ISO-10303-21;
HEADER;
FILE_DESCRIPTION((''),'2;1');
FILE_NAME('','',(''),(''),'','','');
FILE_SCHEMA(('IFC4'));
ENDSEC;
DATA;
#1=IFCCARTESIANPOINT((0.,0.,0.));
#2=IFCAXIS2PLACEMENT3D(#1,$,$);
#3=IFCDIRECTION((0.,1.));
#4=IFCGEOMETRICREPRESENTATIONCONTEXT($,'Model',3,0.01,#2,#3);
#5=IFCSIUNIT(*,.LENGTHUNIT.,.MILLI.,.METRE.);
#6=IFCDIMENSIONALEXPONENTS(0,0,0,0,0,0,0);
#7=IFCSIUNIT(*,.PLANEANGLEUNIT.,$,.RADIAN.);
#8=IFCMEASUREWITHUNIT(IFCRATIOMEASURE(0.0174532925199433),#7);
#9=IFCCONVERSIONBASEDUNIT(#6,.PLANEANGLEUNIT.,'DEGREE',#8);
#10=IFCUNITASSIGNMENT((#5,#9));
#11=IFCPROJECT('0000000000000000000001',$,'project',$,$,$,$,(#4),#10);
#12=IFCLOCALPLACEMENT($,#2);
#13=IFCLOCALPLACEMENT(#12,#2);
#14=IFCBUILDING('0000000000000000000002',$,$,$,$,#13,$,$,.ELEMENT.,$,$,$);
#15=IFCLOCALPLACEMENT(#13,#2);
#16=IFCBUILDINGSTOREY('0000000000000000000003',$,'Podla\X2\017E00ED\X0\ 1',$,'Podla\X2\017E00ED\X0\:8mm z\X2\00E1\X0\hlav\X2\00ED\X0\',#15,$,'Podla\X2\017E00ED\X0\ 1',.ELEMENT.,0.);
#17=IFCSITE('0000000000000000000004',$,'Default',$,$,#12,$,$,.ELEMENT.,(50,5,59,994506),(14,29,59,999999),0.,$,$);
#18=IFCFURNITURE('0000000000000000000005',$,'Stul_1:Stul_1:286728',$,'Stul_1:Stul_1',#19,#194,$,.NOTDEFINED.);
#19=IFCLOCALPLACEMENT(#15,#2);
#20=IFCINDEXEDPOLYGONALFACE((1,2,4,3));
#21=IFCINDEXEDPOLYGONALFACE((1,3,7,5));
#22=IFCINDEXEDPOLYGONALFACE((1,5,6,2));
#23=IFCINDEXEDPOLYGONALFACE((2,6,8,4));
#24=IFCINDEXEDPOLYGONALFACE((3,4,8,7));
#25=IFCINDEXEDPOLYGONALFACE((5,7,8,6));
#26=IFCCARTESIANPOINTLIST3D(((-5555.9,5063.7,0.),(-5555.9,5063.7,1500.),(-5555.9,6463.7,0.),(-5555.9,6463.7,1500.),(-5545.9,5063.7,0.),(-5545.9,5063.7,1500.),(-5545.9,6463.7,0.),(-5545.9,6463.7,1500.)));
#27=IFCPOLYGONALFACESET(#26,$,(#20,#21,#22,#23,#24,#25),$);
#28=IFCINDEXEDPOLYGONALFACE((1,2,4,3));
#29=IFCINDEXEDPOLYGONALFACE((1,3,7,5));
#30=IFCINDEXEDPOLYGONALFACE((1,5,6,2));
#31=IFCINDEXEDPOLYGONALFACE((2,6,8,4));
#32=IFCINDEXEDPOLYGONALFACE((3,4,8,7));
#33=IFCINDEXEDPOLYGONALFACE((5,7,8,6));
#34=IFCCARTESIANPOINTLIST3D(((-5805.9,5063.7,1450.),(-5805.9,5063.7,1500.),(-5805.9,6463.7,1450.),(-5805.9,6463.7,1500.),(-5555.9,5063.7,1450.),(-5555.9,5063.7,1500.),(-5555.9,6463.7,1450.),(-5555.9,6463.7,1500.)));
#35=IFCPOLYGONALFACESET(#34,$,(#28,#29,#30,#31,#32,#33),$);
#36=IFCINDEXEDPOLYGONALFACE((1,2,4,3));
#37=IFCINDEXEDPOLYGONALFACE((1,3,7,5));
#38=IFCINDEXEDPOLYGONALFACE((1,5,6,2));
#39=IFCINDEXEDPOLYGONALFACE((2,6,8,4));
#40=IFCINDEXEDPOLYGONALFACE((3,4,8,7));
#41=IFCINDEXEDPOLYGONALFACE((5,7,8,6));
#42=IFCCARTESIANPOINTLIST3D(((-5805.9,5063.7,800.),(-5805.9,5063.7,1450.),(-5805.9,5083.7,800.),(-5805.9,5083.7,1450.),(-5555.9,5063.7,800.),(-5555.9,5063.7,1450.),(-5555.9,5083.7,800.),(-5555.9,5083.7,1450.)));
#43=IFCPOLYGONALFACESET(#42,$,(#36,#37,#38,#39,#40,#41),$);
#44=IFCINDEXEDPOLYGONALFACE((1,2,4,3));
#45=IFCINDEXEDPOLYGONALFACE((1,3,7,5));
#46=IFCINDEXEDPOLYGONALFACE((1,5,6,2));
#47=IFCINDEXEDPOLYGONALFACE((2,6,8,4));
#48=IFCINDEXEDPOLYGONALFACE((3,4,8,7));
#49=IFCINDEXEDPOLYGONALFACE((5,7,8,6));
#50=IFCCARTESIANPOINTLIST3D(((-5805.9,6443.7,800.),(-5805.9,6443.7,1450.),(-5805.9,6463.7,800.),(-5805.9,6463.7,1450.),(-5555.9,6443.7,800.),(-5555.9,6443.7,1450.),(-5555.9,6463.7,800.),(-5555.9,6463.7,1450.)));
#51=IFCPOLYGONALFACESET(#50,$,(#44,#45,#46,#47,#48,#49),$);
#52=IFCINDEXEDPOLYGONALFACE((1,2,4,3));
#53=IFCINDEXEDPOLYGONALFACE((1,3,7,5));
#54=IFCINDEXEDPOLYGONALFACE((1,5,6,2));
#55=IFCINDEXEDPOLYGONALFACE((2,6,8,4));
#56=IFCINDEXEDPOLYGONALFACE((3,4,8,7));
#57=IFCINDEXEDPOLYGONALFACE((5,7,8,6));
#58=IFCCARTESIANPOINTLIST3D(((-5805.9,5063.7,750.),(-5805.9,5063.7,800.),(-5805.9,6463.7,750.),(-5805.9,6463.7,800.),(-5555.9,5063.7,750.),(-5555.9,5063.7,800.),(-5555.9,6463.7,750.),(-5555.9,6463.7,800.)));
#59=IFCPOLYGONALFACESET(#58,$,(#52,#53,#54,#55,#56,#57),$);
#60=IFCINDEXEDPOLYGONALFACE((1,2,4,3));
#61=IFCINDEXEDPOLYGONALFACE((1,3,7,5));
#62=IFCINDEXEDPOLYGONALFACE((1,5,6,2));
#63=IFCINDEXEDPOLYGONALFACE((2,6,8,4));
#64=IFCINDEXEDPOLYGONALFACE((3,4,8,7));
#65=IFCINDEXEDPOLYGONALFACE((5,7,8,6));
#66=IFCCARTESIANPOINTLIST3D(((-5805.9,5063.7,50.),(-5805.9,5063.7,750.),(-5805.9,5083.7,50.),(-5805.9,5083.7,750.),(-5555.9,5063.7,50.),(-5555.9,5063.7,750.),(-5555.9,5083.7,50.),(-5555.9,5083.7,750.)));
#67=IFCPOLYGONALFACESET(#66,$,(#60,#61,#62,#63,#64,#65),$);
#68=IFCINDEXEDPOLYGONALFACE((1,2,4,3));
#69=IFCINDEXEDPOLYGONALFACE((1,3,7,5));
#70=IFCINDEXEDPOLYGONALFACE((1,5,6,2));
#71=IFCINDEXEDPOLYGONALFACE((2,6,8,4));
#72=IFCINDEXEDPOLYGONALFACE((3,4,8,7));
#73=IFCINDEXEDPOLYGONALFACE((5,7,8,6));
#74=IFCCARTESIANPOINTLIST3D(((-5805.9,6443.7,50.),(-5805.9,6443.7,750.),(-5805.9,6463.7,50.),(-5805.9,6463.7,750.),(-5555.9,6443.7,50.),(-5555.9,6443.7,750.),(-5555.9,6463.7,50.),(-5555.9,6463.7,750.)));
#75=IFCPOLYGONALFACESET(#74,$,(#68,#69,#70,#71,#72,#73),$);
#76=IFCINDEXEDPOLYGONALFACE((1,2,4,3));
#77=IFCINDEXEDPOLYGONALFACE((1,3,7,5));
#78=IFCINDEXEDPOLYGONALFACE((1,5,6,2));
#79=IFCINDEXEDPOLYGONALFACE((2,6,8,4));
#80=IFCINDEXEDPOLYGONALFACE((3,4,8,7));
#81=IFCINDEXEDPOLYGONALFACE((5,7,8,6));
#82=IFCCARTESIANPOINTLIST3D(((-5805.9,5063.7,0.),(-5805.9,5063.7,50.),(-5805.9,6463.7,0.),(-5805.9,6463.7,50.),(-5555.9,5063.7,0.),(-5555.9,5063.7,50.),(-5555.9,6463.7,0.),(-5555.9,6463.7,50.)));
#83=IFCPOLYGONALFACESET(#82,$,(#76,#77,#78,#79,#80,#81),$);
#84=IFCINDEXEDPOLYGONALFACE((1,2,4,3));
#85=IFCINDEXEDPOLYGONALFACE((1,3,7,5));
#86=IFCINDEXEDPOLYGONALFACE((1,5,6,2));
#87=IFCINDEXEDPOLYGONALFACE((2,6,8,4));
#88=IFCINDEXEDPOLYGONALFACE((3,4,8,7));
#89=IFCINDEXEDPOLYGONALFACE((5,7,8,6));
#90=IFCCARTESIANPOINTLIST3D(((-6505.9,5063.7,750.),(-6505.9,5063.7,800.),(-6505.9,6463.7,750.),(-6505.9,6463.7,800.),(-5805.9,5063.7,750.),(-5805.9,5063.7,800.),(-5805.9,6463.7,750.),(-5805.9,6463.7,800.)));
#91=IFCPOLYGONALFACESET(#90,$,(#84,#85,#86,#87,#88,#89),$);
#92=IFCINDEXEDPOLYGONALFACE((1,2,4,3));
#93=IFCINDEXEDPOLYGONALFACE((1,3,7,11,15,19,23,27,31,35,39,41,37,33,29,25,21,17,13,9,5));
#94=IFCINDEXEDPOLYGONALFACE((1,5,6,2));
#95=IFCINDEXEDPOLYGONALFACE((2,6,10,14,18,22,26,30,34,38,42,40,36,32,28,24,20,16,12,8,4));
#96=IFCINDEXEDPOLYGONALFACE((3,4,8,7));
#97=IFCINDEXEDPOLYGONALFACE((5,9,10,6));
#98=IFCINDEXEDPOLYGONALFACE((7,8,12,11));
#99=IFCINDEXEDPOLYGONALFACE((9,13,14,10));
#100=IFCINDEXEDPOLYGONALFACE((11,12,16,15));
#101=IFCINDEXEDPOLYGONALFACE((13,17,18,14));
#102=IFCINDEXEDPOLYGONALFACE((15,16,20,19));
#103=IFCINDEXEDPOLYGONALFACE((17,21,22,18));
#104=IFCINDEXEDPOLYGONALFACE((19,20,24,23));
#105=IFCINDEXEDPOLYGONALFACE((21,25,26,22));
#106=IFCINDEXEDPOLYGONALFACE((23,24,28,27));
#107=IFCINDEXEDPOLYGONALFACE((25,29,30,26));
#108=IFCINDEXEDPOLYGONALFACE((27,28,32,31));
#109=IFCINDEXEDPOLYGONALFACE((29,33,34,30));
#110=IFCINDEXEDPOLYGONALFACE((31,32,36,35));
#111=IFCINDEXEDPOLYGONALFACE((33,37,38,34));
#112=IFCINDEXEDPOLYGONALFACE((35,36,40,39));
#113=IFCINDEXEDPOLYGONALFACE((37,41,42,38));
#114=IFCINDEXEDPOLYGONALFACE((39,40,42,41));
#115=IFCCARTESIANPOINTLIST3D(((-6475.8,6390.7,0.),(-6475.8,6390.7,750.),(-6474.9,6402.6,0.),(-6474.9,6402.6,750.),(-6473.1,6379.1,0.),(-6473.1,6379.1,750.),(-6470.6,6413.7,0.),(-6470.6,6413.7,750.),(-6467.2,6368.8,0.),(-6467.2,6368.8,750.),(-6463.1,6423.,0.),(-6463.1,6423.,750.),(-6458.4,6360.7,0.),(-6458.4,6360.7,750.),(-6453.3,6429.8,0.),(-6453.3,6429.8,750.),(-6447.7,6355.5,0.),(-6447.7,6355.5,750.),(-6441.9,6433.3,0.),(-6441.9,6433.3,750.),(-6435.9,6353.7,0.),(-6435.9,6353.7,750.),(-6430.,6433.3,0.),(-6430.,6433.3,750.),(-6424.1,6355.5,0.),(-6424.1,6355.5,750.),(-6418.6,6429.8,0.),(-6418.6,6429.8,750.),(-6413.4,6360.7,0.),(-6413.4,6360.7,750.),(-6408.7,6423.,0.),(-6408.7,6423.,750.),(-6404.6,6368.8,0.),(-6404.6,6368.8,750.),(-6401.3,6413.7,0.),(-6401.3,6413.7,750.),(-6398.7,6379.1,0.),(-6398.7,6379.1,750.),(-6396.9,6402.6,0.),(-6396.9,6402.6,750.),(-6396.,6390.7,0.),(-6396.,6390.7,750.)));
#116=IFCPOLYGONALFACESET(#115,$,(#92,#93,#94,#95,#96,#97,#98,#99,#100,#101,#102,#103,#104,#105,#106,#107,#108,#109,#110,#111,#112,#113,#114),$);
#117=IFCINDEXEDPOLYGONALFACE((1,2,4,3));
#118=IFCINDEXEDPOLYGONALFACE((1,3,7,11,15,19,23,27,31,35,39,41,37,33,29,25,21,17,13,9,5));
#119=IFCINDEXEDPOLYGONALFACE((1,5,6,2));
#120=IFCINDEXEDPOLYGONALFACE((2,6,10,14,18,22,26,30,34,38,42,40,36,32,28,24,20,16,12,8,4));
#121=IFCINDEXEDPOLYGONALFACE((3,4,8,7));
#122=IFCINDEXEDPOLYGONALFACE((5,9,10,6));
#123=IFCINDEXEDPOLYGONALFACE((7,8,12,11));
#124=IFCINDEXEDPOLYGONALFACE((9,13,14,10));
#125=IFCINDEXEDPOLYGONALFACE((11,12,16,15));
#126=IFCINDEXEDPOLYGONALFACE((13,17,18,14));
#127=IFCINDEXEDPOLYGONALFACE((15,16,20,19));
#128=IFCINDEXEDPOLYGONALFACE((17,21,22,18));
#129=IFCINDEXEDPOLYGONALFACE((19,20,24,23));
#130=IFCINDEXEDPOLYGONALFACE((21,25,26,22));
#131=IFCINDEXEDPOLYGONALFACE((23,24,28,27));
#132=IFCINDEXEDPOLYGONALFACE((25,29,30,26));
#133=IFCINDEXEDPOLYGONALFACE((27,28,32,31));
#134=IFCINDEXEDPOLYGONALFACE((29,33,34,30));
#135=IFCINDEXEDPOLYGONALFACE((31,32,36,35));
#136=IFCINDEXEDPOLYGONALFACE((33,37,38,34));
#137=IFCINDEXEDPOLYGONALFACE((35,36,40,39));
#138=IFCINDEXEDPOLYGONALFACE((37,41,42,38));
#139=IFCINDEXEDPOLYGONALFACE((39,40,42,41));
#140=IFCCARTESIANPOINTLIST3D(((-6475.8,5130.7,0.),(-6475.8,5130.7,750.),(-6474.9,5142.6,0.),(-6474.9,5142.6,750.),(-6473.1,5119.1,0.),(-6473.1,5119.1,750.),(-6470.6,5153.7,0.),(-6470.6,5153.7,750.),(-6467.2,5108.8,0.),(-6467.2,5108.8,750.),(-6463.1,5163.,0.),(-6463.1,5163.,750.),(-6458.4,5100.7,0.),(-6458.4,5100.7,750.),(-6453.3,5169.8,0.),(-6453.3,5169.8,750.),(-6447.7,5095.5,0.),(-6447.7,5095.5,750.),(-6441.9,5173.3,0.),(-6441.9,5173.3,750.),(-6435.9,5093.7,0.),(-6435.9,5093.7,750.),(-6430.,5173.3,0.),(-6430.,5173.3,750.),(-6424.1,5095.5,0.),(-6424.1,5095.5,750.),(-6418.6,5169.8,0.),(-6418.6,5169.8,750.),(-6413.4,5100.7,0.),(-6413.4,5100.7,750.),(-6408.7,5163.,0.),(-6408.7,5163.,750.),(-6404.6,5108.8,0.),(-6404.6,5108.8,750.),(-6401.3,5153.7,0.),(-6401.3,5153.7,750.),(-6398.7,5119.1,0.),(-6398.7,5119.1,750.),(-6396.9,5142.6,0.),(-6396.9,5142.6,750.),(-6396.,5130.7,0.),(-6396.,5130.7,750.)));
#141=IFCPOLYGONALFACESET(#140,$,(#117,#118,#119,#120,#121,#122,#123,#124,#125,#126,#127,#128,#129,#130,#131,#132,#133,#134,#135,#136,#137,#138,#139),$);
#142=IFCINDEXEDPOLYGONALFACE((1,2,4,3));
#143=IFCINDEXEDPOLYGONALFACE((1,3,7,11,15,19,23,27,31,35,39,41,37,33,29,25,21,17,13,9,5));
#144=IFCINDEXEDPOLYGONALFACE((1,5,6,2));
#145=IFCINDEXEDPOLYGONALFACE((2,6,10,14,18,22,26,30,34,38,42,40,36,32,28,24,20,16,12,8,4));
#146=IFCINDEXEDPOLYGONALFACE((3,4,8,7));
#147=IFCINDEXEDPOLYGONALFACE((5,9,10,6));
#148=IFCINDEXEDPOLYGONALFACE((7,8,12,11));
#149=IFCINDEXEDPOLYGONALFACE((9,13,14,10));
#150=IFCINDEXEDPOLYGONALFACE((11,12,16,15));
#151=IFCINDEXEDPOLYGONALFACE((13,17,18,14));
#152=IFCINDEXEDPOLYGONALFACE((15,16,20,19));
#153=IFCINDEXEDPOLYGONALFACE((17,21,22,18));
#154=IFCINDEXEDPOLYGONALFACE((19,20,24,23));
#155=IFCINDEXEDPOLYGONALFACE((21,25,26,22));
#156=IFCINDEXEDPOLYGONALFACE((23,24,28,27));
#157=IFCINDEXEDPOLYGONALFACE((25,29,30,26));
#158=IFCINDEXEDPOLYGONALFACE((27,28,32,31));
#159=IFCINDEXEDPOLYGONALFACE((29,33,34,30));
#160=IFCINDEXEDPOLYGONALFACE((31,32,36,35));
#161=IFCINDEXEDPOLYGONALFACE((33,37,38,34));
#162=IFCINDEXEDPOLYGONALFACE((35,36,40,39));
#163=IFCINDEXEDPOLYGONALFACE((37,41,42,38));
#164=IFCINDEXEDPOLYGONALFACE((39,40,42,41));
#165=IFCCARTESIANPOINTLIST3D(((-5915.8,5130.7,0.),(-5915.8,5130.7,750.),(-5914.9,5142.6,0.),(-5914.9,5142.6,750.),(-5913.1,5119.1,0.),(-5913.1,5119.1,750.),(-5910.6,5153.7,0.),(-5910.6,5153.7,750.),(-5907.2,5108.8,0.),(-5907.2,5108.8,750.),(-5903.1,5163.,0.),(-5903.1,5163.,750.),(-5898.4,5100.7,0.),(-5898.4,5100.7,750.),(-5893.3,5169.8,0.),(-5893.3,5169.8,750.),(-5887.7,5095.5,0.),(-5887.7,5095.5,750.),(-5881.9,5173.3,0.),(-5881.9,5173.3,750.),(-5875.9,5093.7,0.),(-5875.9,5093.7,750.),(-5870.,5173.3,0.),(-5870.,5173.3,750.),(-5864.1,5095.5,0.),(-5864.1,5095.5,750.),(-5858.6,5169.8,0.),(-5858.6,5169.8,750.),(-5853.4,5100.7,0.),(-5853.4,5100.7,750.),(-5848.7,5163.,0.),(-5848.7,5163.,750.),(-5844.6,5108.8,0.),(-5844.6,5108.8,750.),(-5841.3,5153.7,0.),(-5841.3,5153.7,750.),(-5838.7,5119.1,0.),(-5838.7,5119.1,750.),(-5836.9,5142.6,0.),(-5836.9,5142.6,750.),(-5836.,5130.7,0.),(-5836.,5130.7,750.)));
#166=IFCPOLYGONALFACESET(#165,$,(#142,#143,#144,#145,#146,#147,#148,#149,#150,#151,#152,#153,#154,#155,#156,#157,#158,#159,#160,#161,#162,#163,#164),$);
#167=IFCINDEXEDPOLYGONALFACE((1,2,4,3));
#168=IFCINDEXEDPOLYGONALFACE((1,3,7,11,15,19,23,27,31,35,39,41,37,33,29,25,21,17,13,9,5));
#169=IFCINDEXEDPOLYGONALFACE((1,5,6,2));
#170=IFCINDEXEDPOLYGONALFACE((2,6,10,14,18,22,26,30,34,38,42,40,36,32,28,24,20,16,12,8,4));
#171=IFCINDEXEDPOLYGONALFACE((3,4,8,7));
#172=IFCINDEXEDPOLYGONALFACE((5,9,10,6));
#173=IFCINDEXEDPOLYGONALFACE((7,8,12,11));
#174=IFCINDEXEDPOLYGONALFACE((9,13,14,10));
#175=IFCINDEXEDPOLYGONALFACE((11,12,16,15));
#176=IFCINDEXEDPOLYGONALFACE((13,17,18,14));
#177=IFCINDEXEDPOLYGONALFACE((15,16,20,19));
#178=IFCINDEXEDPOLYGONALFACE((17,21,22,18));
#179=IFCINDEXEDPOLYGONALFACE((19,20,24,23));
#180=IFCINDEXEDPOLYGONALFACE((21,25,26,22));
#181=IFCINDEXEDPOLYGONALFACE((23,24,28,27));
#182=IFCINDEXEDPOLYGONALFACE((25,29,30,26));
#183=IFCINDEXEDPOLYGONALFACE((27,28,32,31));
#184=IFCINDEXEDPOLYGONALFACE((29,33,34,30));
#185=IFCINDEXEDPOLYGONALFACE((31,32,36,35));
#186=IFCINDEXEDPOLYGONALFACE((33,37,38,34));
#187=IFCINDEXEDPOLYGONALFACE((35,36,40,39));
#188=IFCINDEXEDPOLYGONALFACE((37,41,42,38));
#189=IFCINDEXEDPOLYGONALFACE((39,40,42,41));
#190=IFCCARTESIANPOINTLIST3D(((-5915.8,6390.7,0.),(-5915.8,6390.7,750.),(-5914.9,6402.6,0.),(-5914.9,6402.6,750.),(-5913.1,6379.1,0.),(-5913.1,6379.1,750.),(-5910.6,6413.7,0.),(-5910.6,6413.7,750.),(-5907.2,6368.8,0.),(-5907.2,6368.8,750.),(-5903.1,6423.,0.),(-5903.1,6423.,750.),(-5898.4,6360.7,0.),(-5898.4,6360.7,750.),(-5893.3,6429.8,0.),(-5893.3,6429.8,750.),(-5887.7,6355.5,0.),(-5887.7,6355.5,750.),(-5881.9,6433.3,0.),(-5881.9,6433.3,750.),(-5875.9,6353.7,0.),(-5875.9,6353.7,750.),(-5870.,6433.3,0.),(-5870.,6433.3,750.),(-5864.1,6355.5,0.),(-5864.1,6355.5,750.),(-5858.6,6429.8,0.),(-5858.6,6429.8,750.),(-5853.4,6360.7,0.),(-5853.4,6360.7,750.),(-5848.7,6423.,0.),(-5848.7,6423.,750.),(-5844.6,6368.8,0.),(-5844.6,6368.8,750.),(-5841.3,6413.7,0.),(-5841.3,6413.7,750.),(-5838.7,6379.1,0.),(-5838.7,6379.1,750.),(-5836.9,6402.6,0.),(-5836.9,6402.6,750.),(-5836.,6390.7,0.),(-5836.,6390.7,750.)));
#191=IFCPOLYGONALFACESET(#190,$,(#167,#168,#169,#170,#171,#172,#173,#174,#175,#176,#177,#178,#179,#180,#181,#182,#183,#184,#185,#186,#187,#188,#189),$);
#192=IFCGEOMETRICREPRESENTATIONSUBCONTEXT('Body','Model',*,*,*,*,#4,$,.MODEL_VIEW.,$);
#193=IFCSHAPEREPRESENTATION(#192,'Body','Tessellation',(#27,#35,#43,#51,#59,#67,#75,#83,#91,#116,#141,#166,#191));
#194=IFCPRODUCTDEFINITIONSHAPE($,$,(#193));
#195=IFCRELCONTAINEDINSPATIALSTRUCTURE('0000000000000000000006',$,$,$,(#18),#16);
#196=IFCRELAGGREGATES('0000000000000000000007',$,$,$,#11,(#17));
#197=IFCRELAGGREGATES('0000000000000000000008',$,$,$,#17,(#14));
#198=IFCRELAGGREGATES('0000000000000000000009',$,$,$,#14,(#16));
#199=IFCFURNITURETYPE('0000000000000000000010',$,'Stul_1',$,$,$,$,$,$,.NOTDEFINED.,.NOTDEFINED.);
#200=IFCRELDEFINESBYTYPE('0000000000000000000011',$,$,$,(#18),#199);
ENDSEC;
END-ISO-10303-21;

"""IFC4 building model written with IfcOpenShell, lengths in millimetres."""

from ifc_helpers import new_model, entity, si_unit, converted_unit, direction, frame, frame_2d, origin, origin_2d_with_axis, place, context, subcontext, project, spatial, rectangle, circle, extrude, source, transform, mapped, type_object, type_shapes, element, save


model = new_model("IFC4")

# Units and contexts
model_context = context("Model", 3, precision=0.01, world=origin(), true_north=direction((0.0, 1.0)))
body_context = subcontext(model_context, "Body", "Model", "MODEL_VIEW")
ifc_project = project(units=[si_unit("LENGTHUNIT", "METRE", prefix="MILLI"), converted_unit("PLANEANGLEUNIT", "DEGREE", entity("IfcRatioMeasure", 0.0174532925199433), si_unit("PLANEANGLEUNIT", "RADIAN"), dimensions=[0, 0, 0, 0, 0, 0, 0])], contexts=[model_context])

# Site, building, storey
site_placement = place(None, origin())
site = spatial("IfcSite", under=ifc_project, at=site_placement, Name="Default", CompositionType="ELEMENT", RefLatitude=(50, 5, 59, 994506), RefLongitude=(14, 29, 59, 999999), RefElevation=0.0)
building_placement = place(site_placement, origin())
building = spatial("IfcBuilding", under=site, at=building_placement, CompositionType="ELEMENT")
storey_placement = place(building_placement, origin())
storey = spatial("IfcBuildingStorey", under=building, at=storey_placement, Name="Podlaží 1", ObjectType="Podlaží:8mm záhlaví", LongName="Podlaží 1", CompositionType="ELEMENT", Elevation=0.0)

# Furniture
furniture_type = type_object("IfcFurnitureType", Name="Stul_1", AssemblyPlace="NOTDEFINED", PredefinedType="NOTDEFINED")
shared_shape_1 = source(origin(), body_context, "Body", "SweptSolid", [
    extrude(rectangle(XDim=1400.0, YDim=10.0, at=origin_2d_with_axis()), frame((0.0, 605.0, 0.0), z_axis=(0.0, 0.0, 1.0), x_axis=(-1.0, 0.0, 0.0)), (0.0, 0.0, 1.0), 1500.0),
    extrude(rectangle(XDim=1400.0, YDim=250.0, at=frame_2d((0.0, 0.0), x_axis=(1.0, 0.0))), frame((0.0, 475.0, 1450.0), z_axis=(0.0, 0.0, 1.0), x_axis=(-1.0, 0.0, 0.0)), (0.0, 0.0, 1.0), 50.0),
    extrude(rectangle(XDim=20.0, YDim=250.0, at=origin_2d_with_axis()), frame((690.0, 475.0, 800.0), z_axis=(0.0, 0.0, 1.0), x_axis=(-1.0, 0.0, 0.0)), (0.0, 0.0, 1.0), 650.0),
    extrude(rectangle(XDim=20.0, YDim=250.0, at=frame_2d((0.0, 0.0), x_axis=(1.0, 0.0))), frame((-690.0, 475.0, 800.0), z_axis=(0.0, 0.0, 1.0), x_axis=(-1.0, 0.0, 0.0)), (0.0, 0.0, 1.0), 650.0),
    extrude(rectangle(XDim=1400.0, YDim=250.0, at=origin_2d_with_axis()), frame((0.0, 475.0, 750.0), z_axis=(0.0, 0.0, 1.0), x_axis=(-1.0, 0.0, 0.0)), (0.0, 0.0, 1.0), 50.0),
    extrude(rectangle(XDim=20.0, YDim=250.0, at=origin_2d_with_axis()), frame((690.0, 475.0, 50.0), z_axis=(0.0, 0.0, 1.0), x_axis=(-1.0, 0.0, 0.0)), (0.0, 0.0, 1.0), 700.0),
    extrude(rectangle(XDim=20.0, YDim=250.0, at=frame_2d((0.0, 0.0), x_axis=(1.0, 0.0))), frame((-690.0, 475.0, 50.0), z_axis=(0.0, 0.0, 1.0), x_axis=(-1.0, 0.0, 0.0)), (0.0, 0.0, 1.0), 700.0),
    extrude(rectangle(XDim=1400.0, YDim=250.0, at=origin_2d_with_axis()), frame((0.0, 475.0, 0.0), z_axis=(0.0, 0.0, 1.0), x_axis=(-1.0, 0.0, 0.0)), (0.0, 0.0, 1.0), 50.0),
    extrude(rectangle(XDim=1400.0, YDim=700.0, at=origin_2d_with_axis()), frame((0.0, 0.0, 750.0), z_axis=(0.0, 0.0, 1.0), x_axis=(-1.0, 0.0, 0.0)), (0.0, 0.0, 1.0), 50.0),
    extrude(circle(Radius=40.0, at=frame_2d((0.0, 0.0), x_axis=(1.0, 0.0))), frame((-630.0, -280.0, 0.0)), (0.0, 0.0, 1.0), 750.0),
    extrude(circle(Radius=40.0, at=frame_2d((0.0, 0.0), x_axis=(1.0, 0.0))), frame((630.0, -280.0, 0.0)), (0.0, 0.0, 1.0), 750.0),
    extrude(circle(Radius=40.0, at=frame_2d((0.0, 0.0), x_axis=(1.0, 0.0))), frame((630.0, 280.0, 0.0)), (0.0, 0.0, 1.0), 750.0),
    extrude(circle(Radius=40.0, at=frame_2d((0.0, 0.0), x_axis=(1.0, 0.0))), frame((-630.0, 280.0, 0.0)), (0.0, 0.0, 1.0), 750.0),
])
type_shapes(furniture_type, [shared_shape_1])
for number, where, z_axis, x_axis, name in (
    (1, (-6155.9, 5763.7, 0.0), (0.0, 0.0, 1.0), (0.0, -1.0, 0.0), "Stul_1:Stul_1:286728"),
):
    element("IfcFurniture", number, at=place(storey_placement, frame(where, z_axis=z_axis, x_axis=x_axis)), inside=storey, type_object=furniture_type, Name=name, ObjectType="Stul_1:Stul_1", PredefinedType="NOTDEFINED", context=body_context, shape_type="MappedRepresentation", body=[
        mapped(shared_shape_1, transform((0.0, 0.0, 0.0), scale=1.0)),
    ])

save(model, "model.ifc")
